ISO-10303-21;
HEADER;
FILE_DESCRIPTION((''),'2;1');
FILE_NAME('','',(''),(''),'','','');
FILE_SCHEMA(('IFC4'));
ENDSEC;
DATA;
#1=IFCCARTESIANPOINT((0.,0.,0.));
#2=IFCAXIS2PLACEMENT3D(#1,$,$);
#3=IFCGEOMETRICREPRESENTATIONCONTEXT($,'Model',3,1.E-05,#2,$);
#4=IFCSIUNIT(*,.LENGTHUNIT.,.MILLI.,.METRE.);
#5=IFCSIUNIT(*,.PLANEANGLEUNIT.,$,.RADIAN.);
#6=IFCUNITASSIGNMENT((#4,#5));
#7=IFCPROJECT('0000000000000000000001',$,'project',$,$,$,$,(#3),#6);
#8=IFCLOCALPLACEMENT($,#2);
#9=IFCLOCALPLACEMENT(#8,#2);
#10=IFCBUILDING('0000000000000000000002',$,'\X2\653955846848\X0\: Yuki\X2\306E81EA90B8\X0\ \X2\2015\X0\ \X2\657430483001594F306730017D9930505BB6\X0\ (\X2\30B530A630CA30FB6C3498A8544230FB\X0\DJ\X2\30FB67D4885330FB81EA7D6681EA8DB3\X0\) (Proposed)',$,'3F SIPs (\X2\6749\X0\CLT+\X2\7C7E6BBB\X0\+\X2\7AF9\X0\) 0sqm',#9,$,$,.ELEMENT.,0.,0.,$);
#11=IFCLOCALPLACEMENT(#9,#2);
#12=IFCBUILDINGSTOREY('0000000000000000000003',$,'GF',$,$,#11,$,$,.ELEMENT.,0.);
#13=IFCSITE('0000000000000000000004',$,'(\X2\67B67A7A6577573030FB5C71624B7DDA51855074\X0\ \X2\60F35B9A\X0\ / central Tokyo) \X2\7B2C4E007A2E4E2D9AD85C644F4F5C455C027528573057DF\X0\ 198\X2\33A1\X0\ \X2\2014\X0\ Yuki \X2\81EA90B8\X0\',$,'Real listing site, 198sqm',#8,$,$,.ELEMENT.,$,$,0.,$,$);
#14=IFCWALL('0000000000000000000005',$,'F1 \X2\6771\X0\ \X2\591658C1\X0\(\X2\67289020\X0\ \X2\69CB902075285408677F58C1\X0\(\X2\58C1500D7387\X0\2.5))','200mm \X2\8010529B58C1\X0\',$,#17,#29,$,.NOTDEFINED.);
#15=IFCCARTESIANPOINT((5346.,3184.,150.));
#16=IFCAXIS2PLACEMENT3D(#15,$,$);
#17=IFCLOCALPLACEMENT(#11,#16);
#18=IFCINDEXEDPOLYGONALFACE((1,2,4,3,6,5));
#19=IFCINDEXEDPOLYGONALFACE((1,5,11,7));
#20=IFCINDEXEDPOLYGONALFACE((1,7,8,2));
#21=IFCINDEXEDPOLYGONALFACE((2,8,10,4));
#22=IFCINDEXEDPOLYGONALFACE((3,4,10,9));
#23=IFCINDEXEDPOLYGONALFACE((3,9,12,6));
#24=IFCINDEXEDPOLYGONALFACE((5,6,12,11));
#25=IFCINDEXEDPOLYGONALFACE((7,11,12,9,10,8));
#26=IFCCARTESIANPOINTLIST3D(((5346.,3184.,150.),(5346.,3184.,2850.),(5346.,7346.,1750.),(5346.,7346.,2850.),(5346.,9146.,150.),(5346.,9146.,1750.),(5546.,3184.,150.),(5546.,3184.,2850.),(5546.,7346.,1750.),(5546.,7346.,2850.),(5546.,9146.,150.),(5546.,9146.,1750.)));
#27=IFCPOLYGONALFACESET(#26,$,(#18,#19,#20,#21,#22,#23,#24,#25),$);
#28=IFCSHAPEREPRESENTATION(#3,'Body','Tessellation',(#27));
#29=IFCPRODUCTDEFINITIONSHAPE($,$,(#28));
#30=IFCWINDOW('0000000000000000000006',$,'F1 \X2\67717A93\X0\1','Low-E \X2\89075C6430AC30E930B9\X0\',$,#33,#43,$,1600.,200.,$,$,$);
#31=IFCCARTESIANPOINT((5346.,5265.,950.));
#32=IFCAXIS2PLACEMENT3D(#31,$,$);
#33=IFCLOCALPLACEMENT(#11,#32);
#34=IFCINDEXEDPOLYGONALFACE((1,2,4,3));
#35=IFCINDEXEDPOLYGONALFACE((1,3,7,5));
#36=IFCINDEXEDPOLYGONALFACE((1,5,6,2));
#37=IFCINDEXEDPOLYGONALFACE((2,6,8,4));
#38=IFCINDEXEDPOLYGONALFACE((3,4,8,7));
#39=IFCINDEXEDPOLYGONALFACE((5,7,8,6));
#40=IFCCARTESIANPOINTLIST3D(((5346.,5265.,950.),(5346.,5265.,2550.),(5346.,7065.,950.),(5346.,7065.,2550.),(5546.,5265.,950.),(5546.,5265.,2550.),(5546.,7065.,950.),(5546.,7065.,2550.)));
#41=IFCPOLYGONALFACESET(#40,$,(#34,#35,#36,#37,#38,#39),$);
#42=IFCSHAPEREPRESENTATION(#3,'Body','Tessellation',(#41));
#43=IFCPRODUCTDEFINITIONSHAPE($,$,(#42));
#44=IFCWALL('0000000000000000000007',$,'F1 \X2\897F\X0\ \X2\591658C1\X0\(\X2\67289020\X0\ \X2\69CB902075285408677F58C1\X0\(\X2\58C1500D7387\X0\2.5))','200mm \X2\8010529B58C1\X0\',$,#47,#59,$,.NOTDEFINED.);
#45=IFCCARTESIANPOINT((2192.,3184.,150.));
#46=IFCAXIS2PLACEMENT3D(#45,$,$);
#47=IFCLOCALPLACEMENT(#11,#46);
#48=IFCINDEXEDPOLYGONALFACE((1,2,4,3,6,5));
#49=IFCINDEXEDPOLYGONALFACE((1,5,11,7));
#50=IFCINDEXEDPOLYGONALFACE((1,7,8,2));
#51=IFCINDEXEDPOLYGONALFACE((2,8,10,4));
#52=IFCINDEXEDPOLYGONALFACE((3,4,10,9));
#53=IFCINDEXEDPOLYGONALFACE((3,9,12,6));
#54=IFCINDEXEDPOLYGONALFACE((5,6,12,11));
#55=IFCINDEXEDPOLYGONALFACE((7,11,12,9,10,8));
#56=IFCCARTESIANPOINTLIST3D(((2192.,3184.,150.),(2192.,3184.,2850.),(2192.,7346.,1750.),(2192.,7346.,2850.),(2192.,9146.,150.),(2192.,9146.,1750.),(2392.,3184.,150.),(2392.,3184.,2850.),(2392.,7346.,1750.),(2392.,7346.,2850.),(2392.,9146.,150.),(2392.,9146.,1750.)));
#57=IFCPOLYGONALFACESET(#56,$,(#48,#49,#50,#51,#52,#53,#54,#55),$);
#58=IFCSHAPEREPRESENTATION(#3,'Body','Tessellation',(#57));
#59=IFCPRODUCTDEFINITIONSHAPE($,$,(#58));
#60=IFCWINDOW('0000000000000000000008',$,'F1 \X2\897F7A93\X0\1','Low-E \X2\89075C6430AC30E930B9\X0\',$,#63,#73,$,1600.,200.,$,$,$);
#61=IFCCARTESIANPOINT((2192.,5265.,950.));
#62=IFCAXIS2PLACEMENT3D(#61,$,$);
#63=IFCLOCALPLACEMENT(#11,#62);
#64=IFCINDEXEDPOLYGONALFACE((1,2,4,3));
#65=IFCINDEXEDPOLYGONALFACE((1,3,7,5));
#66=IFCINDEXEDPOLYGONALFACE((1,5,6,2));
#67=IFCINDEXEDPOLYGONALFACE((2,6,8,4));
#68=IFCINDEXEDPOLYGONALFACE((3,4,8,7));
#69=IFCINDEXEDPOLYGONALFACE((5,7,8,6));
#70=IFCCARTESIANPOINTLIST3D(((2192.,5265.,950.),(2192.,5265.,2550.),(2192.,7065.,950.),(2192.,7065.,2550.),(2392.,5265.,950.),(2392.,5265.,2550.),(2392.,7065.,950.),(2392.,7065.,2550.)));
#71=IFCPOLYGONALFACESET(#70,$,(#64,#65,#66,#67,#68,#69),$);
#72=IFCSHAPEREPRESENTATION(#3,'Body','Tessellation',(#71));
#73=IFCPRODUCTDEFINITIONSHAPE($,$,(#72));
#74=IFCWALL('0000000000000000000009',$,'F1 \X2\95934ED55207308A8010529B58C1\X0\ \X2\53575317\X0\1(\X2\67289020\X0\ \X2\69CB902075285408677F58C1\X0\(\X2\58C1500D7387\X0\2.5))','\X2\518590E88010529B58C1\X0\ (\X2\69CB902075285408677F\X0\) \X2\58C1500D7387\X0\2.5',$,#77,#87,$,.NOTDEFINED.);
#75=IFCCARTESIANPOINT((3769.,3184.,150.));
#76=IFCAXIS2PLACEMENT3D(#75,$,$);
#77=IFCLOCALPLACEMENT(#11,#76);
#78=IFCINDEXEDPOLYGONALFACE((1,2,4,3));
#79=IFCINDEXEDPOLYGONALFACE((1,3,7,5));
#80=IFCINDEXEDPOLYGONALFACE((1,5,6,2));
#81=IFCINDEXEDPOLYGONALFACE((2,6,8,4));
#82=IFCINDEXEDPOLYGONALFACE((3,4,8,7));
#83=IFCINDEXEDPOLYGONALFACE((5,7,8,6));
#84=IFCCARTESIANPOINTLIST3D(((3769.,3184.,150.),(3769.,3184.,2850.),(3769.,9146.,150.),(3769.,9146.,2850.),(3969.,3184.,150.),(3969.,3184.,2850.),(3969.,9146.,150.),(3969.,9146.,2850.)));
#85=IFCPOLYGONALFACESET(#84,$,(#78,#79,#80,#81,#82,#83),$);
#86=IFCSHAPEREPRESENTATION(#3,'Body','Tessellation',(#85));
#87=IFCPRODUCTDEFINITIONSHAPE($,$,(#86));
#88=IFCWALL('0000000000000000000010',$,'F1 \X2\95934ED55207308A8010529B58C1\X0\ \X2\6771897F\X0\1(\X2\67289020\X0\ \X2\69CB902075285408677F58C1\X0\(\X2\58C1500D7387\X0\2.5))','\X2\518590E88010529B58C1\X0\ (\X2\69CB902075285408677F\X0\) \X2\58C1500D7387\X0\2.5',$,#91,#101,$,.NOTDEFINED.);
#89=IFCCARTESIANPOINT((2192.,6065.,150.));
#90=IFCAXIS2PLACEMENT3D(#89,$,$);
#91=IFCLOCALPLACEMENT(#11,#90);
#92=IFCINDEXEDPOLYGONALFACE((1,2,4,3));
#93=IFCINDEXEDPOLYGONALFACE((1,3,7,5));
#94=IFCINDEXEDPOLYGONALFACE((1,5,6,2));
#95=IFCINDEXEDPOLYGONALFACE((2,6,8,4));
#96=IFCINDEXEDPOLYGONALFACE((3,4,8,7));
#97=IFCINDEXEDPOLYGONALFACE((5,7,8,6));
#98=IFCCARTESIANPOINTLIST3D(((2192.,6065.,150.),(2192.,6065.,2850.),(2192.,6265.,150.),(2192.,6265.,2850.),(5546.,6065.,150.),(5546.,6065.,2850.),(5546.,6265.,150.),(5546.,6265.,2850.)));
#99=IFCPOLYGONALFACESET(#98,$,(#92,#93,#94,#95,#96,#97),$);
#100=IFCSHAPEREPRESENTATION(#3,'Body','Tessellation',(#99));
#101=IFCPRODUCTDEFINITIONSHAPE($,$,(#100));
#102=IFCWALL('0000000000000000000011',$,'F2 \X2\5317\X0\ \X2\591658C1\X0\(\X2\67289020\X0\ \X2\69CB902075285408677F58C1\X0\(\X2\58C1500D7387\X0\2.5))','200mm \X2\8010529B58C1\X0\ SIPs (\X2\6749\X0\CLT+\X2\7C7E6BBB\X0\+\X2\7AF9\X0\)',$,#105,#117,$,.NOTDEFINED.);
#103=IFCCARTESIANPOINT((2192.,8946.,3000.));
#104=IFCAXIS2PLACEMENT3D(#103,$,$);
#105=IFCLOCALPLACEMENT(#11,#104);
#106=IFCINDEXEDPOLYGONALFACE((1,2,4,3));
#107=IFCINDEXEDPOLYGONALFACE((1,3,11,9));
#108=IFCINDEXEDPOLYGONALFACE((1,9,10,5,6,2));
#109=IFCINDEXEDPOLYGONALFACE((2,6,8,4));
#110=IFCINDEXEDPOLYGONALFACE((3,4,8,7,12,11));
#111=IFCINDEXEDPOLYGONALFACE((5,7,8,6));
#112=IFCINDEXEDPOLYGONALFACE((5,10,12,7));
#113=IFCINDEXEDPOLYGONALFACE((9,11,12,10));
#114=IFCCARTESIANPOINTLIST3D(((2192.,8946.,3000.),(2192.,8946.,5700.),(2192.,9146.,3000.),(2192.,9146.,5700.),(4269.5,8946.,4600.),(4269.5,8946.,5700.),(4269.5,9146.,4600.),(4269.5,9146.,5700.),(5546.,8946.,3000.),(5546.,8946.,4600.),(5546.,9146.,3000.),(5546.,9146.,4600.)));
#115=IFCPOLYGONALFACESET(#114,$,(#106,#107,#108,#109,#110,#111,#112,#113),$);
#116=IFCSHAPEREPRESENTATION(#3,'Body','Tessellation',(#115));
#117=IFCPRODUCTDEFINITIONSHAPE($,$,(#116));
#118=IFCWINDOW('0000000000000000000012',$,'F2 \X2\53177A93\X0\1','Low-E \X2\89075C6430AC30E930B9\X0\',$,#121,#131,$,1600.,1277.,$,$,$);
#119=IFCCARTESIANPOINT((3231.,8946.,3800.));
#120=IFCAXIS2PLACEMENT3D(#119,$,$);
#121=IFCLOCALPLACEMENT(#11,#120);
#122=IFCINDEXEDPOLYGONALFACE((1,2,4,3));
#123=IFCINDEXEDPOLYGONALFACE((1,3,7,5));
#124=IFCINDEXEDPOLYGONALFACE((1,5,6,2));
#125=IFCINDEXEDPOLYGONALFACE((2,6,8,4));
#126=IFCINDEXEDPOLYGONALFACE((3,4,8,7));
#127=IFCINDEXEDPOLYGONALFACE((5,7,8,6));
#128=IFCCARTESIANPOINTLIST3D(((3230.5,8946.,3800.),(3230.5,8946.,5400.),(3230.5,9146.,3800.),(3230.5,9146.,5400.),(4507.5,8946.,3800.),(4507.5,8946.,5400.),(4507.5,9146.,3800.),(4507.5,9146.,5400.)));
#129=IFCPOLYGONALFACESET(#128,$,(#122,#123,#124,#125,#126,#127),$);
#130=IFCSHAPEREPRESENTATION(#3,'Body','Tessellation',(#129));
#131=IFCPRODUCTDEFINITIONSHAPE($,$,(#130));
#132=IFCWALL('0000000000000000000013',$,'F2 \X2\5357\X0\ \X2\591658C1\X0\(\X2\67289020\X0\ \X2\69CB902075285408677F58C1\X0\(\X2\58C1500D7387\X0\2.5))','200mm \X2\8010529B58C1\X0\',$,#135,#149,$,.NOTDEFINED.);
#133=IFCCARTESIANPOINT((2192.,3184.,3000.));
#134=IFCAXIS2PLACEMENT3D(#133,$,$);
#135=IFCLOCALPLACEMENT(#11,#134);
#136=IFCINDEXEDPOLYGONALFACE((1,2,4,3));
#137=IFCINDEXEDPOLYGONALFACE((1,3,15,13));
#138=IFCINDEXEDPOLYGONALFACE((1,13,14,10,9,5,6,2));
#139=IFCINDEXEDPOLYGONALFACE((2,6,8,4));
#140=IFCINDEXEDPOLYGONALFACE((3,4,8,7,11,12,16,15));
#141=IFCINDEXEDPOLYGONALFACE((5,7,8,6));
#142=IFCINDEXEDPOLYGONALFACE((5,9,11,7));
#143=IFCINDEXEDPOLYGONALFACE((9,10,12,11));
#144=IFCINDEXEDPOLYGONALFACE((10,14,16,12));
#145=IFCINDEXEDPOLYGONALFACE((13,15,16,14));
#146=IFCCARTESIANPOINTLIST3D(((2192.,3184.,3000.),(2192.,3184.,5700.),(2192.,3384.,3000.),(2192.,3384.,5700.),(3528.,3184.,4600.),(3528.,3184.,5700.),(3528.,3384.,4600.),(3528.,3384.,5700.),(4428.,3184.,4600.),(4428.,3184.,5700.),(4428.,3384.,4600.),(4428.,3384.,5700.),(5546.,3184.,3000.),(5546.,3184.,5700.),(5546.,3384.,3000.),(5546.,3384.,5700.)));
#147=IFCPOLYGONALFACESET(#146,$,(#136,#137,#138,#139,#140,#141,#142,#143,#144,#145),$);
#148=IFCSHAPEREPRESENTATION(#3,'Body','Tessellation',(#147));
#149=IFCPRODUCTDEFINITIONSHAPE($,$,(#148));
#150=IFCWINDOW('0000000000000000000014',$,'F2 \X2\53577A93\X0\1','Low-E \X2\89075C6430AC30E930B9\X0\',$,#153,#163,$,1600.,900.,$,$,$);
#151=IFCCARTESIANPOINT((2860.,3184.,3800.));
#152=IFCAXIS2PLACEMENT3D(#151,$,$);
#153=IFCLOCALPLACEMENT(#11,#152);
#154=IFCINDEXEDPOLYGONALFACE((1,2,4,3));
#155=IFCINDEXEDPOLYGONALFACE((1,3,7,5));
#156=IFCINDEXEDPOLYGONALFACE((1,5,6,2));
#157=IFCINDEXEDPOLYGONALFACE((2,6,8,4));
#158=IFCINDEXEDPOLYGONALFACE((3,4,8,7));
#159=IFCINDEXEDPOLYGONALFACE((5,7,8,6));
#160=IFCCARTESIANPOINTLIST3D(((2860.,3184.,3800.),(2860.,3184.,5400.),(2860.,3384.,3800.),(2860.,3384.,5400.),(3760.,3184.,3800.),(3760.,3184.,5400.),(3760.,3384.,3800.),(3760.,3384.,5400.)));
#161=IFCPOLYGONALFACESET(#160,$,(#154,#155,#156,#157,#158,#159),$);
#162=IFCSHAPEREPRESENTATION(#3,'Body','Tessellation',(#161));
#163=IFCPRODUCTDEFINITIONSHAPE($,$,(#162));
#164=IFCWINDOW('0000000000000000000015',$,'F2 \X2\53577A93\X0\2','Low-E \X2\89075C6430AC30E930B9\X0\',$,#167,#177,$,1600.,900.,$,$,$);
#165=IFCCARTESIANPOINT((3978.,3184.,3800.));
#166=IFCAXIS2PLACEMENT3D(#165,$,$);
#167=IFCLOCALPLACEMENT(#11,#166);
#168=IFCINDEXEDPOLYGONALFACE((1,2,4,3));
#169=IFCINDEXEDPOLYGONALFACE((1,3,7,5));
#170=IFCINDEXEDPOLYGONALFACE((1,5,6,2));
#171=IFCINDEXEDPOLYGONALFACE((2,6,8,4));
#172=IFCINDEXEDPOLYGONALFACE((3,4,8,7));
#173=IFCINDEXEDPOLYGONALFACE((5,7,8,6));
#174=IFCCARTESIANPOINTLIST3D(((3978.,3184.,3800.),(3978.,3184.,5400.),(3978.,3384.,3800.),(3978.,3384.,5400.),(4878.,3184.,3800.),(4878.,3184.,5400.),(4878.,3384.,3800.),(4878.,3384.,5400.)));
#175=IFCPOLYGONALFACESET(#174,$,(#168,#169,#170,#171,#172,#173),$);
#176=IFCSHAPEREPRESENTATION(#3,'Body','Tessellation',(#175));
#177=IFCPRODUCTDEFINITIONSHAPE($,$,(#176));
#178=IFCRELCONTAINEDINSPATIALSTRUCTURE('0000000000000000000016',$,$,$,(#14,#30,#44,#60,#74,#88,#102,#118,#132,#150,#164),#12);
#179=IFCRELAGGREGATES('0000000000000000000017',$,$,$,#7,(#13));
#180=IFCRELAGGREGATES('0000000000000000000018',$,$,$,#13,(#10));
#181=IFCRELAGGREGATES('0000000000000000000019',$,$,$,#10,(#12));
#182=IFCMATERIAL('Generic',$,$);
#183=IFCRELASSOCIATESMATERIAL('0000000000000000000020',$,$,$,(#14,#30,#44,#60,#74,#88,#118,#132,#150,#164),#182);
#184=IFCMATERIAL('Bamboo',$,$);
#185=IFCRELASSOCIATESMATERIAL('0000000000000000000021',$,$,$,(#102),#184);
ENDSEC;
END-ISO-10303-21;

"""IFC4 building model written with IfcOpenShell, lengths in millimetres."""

from ifc_helpers import new_model, si_unit, frame, frame_2d, origin, place, context, project, spatial, rectangle, extrude, material, element, fill, save


model = new_model("IFC4")

# Units and contexts
model_context = context("Model", 3, precision=1e-05, world=origin())
ifc_project = project(units=[si_unit("LENGTHUNIT", "METRE", prefix="MILLI"), si_unit("PLANEANGLEUNIT", "RADIAN")], contexts=[model_context])

# Site, building, storey
site_placement = place(None, origin())
site = spatial("IfcSite", under=ifc_project, at=site_placement, Name="(架空敷地・山手線内側 想定 / central Tokyo) 第一種中高層住居専用地域 198㎡ — Yuki 自邸", ObjectType="Real listing site, 198sqm", CompositionType="ELEMENT", RefElevation=0.0)
building_placement = place(site_placement, origin())
building = spatial("IfcBuilding", under=site, at=building_placement, Name="改善案: Yukiの自邸 ― 整え、奏で、継ぐ家 (サウナ・水風呂・DJ・柔術・自給自足) (Proposed)", ObjectType="3F SIPs (杉CLT+籾殻+竹) 0sqm", CompositionType="ELEMENT", ElevationOfRefHeight=0.0, ElevationOfTerrain=0.0)
storey_placement = place(building_placement, origin())
storey = spatial("IfcBuildingStorey", under=building, at=storey_placement, Name="GF", CompositionType="ELEMENT", Elevation=0.0)

# Shared definitions
ifc_material_1 = material(Name="Generic")

# Shared definitions
ifc_material_2 = material(Name="Bamboo")

# Walls, openings, windows
wall_1_placement = place(storey_placement, frame((5346.0, 3184.0, 150.0)))
wall_1 = element("IfcWall", 1, at=wall_1_placement, inside=storey, material=ifc_material_1, Name="F1 東 外壁(木造 構造用合板壁(壁倍率2.5))", Description="200mm 耐力壁", PredefinedType="NOTDEFINED", context=model_context, shape_type="SweptSolid", body=[
    extrude(rectangle(XDim=200.0, YDim=5962.0, at=frame_2d((100.0, 2981.0))), frame((5346.0, 3184.0, 150.0)), (0.0, 0.0, 1.0), 2700.0),
])
opening_1_placement = place(storey_placement, frame((5346.0, 5265.0, 950.0)))
opening_1 = element("IfcOpeningElement", 2, at=opening_1_placement, cuts=wall_1, PredefinedType="NOTDEFINED", context=model_context, shape_type="SweptSolid", body=[
    extrude(rectangle(XDim=200.0, YDim=1800.0, at=frame_2d((100.0, 900.0))), frame((5346.0, 5265.0, 950.0)), (0.0, 0.0, 1.0), 1600.0),
])
window_1_placement = place(storey_placement, frame((5346.0, 5265.0, 950.0)))
window_1 = element("IfcWindow", 3, at=window_1_placement, inside=storey, material=ifc_material_1, Name="F1 東窓1", Description="Low-E 複層ガラス", OverallHeight=1600.0, OverallWidth=200.0, context=model_context, shape_type="SweptSolid", body=[
    extrude(rectangle(XDim=200.0, YDim=1800.0, at=frame_2d((100.0, 900.0))), frame((5346.0, 5265.0, 950.0)), (0.0, 0.0, 1.0), 1600.0),
])
fill(opening_1, window_1)
wall_2_placement = place(storey_placement, frame((2192.0, 3184.0, 150.0)))
wall_2 = element("IfcWall", 4, at=wall_2_placement, inside=storey, material=ifc_material_1, Name="F1 西 外壁(木造 構造用合板壁(壁倍率2.5))", Description="200mm 耐力壁", PredefinedType="NOTDEFINED", context=model_context, shape_type="SweptSolid", body=[
    extrude(rectangle(XDim=200.0, YDim=5962.0, at=frame_2d((100.0, 2981.0))), frame((2192.0, 3184.0, 150.0)), (0.0, 0.0, 1.0), 2700.0),
])
opening_2_placement = place(storey_placement, frame((2192.0, 5265.0, 950.0)))
opening_2 = element("IfcOpeningElement", 5, at=opening_2_placement, cuts=wall_2, PredefinedType="NOTDEFINED", context=model_context, shape_type="SweptSolid", body=[
    extrude(rectangle(XDim=200.0, YDim=1800.0, at=frame_2d((100.0, 900.0))), frame((2192.0, 5265.0, 950.0)), (0.0, 0.0, 1.0), 1600.0),
])
window_2_placement = place(storey_placement, frame((2192.0, 5265.0, 950.0)))
window_2 = element("IfcWindow", 6, at=window_2_placement, inside=storey, material=ifc_material_1, Name="F1 西窓1", Description="Low-E 複層ガラス", OverallHeight=1600.0, OverallWidth=200.0, context=model_context, shape_type="SweptSolid", body=[
    extrude(rectangle(XDim=200.0, YDim=1800.0, at=frame_2d((100.0, 900.0))), frame((2192.0, 5265.0, 950.0)), (0.0, 0.0, 1.0), 1600.0),
])
fill(opening_2, window_2)

# Walls
wall_3_placement = place(storey_placement, frame((3769.0, 3184.0, 150.0)))
element("IfcWall", 7, at=wall_3_placement, inside=storey, material=ifc_material_1, Name="F1 間仕切り耐力壁 南北1(木造 構造用合板壁(壁倍率2.5))", Description="内部耐力壁 (構造用合板) 壁倍率2.5", PredefinedType="NOTDEFINED", context=model_context, shape_type="SweptSolid", body=[
    extrude(rectangle(XDim=200.0, YDim=5962.0, at=frame_2d((100.0, 2981.0))), frame((3769.0, 3184.0, 150.0)), (0.0, 0.0, 1.0), 2700.0),
])
wall_4_placement = place(storey_placement, frame((2192.0, 6065.0, 150.0)))
element("IfcWall", 8, at=wall_4_placement, inside=storey, material=ifc_material_1, Name="F1 間仕切り耐力壁 東西1(木造 構造用合板壁(壁倍率2.5))", Description="内部耐力壁 (構造用合板) 壁倍率2.5", PredefinedType="NOTDEFINED", context=model_context, shape_type="SweptSolid", body=[
    extrude(rectangle(XDim=3354.0, YDim=200.0, at=frame_2d((1677.0, 100.0))), frame((2192.0, 6065.0, 150.0)), (0.0, 0.0, 1.0), 2700.0),
])

# Wall, opening, window
wall_5_placement = place(storey_placement, frame((2192.0, 8946.0, 3000.0)))
wall_5 = element("IfcWall", 9, at=wall_5_placement, inside=storey, material=ifc_material_2, Name="F2 北 外壁(木造 構造用合板壁(壁倍率2.5))", Description="200mm 耐力壁 SIPs (杉CLT+籾殻+竹)", PredefinedType="NOTDEFINED", context=model_context, shape_type="SweptSolid", body=[
    extrude(rectangle(XDim=3354.0, YDim=200.0, at=frame_2d((1677.0, 100.0))), frame((2192.0, 8946.0, 3000.0)), (0.0, 0.0, 1.0), 2700.0),
])
opening_3_placement = place(storey_placement, frame((3231.0, 8946.0, 3800.0)))
opening_3 = element("IfcOpeningElement", 10, at=opening_3_placement, cuts=wall_5, PredefinedType="NOTDEFINED", context=model_context, shape_type="SweptSolid", body=[
    extrude(rectangle(XDim=1277.0, YDim=200.0, at=frame_2d((638.0, 100.0))), frame((3231.0, 8946.0, 3800.0)), (0.0, 0.0, 1.0), 1600.0),
])
window_3_placement = place(storey_placement, frame((3231.0, 8946.0, 3800.0)))
window_3 = element("IfcWindow", 11, at=window_3_placement, inside=storey, material=ifc_material_1, Name="F2 北窓1", Description="Low-E 複層ガラス", OverallHeight=1600.0, OverallWidth=1277.0, context=model_context, shape_type="SweptSolid", body=[
    extrude(rectangle(XDim=1277.0, YDim=200.0, at=frame_2d((638.0, 100.0))), frame((3231.0, 8946.0, 3800.0)), (0.0, 0.0, 1.0), 1600.0),
])
fill(opening_3, window_3)

# Wall, openings, windows
wall_6_placement = place(storey_placement, frame((2192.0, 3184.0, 3000.0)))
wall_6 = element("IfcWall", 12, at=wall_6_placement, inside=storey, material=ifc_material_1, Name="F2 南 外壁(木造 構造用合板壁(壁倍率2.5))", Description="200mm 耐力壁", PredefinedType="NOTDEFINED", context=model_context, shape_type="SweptSolid", body=[
    extrude(rectangle(XDim=3354.0, YDim=200.0, at=frame_2d((1677.0, 100.0))), frame((2192.0, 3184.0, 3000.0)), (0.0, 0.0, 1.0), 2700.0),
])
opening_4_placement = place(storey_placement, frame((2860.0, 3184.0, 3800.0)))
opening_4 = element("IfcOpeningElement", 13, at=opening_4_placement, cuts=wall_6, PredefinedType="NOTDEFINED", context=model_context, shape_type="SweptSolid", body=[
    extrude(rectangle(XDim=900.0, YDim=200.0, at=frame_2d((450.0, 100.0))), frame((2860.0, 3184.0, 3800.0)), (0.0, 0.0, 1.0), 1600.0),
])
opening_5_placement = place(storey_placement, frame((3978.0, 3184.0, 3800.0)))
opening_5 = element("IfcOpeningElement", 14, at=opening_5_placement, cuts=wall_6, PredefinedType="NOTDEFINED", context=model_context, shape_type="SweptSolid", body=[
    extrude(rectangle(XDim=900.0, YDim=200.0, at=frame_2d((450.0, 100.0))), frame((3978.0, 3184.0, 3800.0)), (0.0, 0.0, 1.0), 1600.0),
])
window_4_placement = place(storey_placement, frame((2860.0, 3184.0, 3800.0)))
window_4 = element("IfcWindow", 15, at=window_4_placement, inside=storey, material=ifc_material_1, Name="F2 南窓1", Description="Low-E 複層ガラス", OverallHeight=1600.0, OverallWidth=900.0, context=model_context, shape_type="SweptSolid", body=[
    extrude(rectangle(XDim=900.0, YDim=200.0, at=frame_2d((450.0, 100.0))), frame((2860.0, 3184.0, 3800.0)), (0.0, 0.0, 1.0), 1600.0),
])
fill(opening_4, window_4)
window_5_placement = place(storey_placement, frame((3978.0, 3184.0, 3800.0)))
window_5 = element("IfcWindow", 16, at=window_5_placement, inside=storey, material=ifc_material_1, Name="F2 南窓2", Description="Low-E 複層ガラス", OverallHeight=1600.0, OverallWidth=900.0, context=model_context, shape_type="SweptSolid", body=[
    extrude(rectangle(XDim=900.0, YDim=200.0, at=frame_2d((450.0, 100.0))), frame((3978.0, 3184.0, 3800.0)), (0.0, 0.0, 1.0), 1600.0),
])
fill(opening_5, window_5)

save(model, "model.ifc")
